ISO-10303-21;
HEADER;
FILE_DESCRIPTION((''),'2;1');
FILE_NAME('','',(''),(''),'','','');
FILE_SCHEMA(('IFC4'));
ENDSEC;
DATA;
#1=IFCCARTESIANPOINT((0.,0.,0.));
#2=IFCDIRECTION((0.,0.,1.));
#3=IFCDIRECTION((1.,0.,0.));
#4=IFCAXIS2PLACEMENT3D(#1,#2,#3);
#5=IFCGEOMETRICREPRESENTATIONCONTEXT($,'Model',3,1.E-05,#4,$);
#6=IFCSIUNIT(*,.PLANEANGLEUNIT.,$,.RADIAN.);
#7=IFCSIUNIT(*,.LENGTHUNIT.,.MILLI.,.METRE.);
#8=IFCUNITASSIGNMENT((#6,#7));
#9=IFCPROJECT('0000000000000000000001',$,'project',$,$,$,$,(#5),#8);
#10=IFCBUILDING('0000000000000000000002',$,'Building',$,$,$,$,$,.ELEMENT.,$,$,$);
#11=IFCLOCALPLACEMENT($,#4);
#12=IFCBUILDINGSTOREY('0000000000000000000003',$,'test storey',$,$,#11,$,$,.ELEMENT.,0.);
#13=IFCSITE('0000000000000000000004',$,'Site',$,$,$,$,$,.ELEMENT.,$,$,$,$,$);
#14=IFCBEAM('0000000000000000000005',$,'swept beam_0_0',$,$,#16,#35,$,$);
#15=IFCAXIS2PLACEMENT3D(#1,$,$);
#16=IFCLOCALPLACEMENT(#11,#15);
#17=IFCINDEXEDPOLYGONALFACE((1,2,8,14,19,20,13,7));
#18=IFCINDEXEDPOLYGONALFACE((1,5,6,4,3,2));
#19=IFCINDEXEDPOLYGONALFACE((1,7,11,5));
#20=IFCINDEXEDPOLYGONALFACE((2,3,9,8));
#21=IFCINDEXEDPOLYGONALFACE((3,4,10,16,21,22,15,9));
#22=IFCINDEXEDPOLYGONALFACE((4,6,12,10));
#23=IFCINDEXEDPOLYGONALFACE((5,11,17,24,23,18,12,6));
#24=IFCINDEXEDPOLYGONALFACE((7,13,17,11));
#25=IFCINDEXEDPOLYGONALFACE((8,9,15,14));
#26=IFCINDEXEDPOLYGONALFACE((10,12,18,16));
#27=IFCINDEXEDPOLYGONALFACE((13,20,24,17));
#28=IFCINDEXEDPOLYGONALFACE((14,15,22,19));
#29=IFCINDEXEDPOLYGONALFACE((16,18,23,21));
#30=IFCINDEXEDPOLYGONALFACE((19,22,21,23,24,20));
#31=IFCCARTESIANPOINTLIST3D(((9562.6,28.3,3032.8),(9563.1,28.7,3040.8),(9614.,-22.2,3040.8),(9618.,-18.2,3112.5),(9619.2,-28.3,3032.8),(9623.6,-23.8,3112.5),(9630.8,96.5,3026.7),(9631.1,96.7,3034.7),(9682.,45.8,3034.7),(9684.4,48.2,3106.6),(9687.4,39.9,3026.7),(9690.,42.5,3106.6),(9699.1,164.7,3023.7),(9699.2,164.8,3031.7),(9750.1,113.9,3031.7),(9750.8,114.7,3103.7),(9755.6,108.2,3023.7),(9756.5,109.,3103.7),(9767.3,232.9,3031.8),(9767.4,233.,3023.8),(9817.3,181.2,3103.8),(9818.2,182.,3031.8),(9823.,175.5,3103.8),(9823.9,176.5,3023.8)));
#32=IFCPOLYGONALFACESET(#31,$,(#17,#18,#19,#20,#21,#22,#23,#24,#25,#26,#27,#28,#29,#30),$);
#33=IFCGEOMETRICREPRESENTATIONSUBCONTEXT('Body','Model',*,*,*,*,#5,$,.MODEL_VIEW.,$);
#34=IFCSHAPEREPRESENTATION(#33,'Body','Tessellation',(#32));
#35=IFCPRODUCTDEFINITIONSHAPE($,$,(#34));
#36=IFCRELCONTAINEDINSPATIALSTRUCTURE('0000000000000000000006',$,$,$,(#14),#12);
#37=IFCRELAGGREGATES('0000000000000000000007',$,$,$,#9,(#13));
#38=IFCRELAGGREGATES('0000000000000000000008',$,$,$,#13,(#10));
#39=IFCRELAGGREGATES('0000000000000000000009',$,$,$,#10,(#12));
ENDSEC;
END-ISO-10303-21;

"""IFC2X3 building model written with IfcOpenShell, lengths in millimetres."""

from ifc_helpers import new_model, entity, si_unit, origin_with_axes, place, context, subcontext, project, spatial, element, save


model = new_model("IFC2X3")

# Units and contexts
model_context = context("Model", 3, precision=1e-05, world=origin_with_axes())
body_context = subcontext(model_context, "Body", "Model", "MODEL_VIEW")
ifc_project = project(units=[si_unit("PLANEANGLEUNIT", "RADIAN"), si_unit("LENGTHUNIT", "METRE", prefix="MILLI")], contexts=[model_context])

# Site, building, storey
site = spatial("IfcSite", under=ifc_project, Name="Site", CompositionType="ELEMENT")
building = spatial("IfcBuilding", under=site, Name="Building", CompositionType="ELEMENT")
storey_placement = place(None, origin_with_axes())
storey = spatial("IfcBuildingStorey", under=building, at=storey_placement, Name="test storey", CompositionType="ELEMENT", Elevation=0.0)

# Beam
beam_1_placement = place(storey_placement, origin_with_axes())
element("IfcBeam", 1, at=beam_1_placement, inside=storey, Name="swept beam_0_0", context=body_context, shape_type="SweptSolid", body=[
    entity("IfcRevolvedAreaSolid", entity("IfcArbitraryClosedProfileDef", "AREA", None, entity("IfcPolyline", [entity("IfcCartesianPoint", [-80.0, 40.0]), entity("IfcCartesianPoint", [-80.0, 32.0]), entity("IfcCartesianPoint", [-8.0, 32.0]), entity("IfcCartesianPoint", [-8.0, -40.0]), entity("IfcCartesianPoint", [0.0, -40.0]), entity("IfcCartesianPoint", [0.0, 40.0]), entity("IfcCartesianPoint", [-80.0, 40.0])])), entity("IfcAxis2Placement3D", entity("IfcCartesianPoint", [9590.9, 0.0, 3032.8]), entity("IfcDirection", [-0.7049, -0.7049, 0.0787]), entity("IfcDirection", [-0.0556, -0.0556, -0.9969])), entity("IfcAxis1Placement", entity("IfcCartesianPoint", [-3030.4, 0.0, 0.0]), entity("IfcDirection", [0.0, 1.0, 0.0])), 0.095633),
])

save(model, "model.ifc")
